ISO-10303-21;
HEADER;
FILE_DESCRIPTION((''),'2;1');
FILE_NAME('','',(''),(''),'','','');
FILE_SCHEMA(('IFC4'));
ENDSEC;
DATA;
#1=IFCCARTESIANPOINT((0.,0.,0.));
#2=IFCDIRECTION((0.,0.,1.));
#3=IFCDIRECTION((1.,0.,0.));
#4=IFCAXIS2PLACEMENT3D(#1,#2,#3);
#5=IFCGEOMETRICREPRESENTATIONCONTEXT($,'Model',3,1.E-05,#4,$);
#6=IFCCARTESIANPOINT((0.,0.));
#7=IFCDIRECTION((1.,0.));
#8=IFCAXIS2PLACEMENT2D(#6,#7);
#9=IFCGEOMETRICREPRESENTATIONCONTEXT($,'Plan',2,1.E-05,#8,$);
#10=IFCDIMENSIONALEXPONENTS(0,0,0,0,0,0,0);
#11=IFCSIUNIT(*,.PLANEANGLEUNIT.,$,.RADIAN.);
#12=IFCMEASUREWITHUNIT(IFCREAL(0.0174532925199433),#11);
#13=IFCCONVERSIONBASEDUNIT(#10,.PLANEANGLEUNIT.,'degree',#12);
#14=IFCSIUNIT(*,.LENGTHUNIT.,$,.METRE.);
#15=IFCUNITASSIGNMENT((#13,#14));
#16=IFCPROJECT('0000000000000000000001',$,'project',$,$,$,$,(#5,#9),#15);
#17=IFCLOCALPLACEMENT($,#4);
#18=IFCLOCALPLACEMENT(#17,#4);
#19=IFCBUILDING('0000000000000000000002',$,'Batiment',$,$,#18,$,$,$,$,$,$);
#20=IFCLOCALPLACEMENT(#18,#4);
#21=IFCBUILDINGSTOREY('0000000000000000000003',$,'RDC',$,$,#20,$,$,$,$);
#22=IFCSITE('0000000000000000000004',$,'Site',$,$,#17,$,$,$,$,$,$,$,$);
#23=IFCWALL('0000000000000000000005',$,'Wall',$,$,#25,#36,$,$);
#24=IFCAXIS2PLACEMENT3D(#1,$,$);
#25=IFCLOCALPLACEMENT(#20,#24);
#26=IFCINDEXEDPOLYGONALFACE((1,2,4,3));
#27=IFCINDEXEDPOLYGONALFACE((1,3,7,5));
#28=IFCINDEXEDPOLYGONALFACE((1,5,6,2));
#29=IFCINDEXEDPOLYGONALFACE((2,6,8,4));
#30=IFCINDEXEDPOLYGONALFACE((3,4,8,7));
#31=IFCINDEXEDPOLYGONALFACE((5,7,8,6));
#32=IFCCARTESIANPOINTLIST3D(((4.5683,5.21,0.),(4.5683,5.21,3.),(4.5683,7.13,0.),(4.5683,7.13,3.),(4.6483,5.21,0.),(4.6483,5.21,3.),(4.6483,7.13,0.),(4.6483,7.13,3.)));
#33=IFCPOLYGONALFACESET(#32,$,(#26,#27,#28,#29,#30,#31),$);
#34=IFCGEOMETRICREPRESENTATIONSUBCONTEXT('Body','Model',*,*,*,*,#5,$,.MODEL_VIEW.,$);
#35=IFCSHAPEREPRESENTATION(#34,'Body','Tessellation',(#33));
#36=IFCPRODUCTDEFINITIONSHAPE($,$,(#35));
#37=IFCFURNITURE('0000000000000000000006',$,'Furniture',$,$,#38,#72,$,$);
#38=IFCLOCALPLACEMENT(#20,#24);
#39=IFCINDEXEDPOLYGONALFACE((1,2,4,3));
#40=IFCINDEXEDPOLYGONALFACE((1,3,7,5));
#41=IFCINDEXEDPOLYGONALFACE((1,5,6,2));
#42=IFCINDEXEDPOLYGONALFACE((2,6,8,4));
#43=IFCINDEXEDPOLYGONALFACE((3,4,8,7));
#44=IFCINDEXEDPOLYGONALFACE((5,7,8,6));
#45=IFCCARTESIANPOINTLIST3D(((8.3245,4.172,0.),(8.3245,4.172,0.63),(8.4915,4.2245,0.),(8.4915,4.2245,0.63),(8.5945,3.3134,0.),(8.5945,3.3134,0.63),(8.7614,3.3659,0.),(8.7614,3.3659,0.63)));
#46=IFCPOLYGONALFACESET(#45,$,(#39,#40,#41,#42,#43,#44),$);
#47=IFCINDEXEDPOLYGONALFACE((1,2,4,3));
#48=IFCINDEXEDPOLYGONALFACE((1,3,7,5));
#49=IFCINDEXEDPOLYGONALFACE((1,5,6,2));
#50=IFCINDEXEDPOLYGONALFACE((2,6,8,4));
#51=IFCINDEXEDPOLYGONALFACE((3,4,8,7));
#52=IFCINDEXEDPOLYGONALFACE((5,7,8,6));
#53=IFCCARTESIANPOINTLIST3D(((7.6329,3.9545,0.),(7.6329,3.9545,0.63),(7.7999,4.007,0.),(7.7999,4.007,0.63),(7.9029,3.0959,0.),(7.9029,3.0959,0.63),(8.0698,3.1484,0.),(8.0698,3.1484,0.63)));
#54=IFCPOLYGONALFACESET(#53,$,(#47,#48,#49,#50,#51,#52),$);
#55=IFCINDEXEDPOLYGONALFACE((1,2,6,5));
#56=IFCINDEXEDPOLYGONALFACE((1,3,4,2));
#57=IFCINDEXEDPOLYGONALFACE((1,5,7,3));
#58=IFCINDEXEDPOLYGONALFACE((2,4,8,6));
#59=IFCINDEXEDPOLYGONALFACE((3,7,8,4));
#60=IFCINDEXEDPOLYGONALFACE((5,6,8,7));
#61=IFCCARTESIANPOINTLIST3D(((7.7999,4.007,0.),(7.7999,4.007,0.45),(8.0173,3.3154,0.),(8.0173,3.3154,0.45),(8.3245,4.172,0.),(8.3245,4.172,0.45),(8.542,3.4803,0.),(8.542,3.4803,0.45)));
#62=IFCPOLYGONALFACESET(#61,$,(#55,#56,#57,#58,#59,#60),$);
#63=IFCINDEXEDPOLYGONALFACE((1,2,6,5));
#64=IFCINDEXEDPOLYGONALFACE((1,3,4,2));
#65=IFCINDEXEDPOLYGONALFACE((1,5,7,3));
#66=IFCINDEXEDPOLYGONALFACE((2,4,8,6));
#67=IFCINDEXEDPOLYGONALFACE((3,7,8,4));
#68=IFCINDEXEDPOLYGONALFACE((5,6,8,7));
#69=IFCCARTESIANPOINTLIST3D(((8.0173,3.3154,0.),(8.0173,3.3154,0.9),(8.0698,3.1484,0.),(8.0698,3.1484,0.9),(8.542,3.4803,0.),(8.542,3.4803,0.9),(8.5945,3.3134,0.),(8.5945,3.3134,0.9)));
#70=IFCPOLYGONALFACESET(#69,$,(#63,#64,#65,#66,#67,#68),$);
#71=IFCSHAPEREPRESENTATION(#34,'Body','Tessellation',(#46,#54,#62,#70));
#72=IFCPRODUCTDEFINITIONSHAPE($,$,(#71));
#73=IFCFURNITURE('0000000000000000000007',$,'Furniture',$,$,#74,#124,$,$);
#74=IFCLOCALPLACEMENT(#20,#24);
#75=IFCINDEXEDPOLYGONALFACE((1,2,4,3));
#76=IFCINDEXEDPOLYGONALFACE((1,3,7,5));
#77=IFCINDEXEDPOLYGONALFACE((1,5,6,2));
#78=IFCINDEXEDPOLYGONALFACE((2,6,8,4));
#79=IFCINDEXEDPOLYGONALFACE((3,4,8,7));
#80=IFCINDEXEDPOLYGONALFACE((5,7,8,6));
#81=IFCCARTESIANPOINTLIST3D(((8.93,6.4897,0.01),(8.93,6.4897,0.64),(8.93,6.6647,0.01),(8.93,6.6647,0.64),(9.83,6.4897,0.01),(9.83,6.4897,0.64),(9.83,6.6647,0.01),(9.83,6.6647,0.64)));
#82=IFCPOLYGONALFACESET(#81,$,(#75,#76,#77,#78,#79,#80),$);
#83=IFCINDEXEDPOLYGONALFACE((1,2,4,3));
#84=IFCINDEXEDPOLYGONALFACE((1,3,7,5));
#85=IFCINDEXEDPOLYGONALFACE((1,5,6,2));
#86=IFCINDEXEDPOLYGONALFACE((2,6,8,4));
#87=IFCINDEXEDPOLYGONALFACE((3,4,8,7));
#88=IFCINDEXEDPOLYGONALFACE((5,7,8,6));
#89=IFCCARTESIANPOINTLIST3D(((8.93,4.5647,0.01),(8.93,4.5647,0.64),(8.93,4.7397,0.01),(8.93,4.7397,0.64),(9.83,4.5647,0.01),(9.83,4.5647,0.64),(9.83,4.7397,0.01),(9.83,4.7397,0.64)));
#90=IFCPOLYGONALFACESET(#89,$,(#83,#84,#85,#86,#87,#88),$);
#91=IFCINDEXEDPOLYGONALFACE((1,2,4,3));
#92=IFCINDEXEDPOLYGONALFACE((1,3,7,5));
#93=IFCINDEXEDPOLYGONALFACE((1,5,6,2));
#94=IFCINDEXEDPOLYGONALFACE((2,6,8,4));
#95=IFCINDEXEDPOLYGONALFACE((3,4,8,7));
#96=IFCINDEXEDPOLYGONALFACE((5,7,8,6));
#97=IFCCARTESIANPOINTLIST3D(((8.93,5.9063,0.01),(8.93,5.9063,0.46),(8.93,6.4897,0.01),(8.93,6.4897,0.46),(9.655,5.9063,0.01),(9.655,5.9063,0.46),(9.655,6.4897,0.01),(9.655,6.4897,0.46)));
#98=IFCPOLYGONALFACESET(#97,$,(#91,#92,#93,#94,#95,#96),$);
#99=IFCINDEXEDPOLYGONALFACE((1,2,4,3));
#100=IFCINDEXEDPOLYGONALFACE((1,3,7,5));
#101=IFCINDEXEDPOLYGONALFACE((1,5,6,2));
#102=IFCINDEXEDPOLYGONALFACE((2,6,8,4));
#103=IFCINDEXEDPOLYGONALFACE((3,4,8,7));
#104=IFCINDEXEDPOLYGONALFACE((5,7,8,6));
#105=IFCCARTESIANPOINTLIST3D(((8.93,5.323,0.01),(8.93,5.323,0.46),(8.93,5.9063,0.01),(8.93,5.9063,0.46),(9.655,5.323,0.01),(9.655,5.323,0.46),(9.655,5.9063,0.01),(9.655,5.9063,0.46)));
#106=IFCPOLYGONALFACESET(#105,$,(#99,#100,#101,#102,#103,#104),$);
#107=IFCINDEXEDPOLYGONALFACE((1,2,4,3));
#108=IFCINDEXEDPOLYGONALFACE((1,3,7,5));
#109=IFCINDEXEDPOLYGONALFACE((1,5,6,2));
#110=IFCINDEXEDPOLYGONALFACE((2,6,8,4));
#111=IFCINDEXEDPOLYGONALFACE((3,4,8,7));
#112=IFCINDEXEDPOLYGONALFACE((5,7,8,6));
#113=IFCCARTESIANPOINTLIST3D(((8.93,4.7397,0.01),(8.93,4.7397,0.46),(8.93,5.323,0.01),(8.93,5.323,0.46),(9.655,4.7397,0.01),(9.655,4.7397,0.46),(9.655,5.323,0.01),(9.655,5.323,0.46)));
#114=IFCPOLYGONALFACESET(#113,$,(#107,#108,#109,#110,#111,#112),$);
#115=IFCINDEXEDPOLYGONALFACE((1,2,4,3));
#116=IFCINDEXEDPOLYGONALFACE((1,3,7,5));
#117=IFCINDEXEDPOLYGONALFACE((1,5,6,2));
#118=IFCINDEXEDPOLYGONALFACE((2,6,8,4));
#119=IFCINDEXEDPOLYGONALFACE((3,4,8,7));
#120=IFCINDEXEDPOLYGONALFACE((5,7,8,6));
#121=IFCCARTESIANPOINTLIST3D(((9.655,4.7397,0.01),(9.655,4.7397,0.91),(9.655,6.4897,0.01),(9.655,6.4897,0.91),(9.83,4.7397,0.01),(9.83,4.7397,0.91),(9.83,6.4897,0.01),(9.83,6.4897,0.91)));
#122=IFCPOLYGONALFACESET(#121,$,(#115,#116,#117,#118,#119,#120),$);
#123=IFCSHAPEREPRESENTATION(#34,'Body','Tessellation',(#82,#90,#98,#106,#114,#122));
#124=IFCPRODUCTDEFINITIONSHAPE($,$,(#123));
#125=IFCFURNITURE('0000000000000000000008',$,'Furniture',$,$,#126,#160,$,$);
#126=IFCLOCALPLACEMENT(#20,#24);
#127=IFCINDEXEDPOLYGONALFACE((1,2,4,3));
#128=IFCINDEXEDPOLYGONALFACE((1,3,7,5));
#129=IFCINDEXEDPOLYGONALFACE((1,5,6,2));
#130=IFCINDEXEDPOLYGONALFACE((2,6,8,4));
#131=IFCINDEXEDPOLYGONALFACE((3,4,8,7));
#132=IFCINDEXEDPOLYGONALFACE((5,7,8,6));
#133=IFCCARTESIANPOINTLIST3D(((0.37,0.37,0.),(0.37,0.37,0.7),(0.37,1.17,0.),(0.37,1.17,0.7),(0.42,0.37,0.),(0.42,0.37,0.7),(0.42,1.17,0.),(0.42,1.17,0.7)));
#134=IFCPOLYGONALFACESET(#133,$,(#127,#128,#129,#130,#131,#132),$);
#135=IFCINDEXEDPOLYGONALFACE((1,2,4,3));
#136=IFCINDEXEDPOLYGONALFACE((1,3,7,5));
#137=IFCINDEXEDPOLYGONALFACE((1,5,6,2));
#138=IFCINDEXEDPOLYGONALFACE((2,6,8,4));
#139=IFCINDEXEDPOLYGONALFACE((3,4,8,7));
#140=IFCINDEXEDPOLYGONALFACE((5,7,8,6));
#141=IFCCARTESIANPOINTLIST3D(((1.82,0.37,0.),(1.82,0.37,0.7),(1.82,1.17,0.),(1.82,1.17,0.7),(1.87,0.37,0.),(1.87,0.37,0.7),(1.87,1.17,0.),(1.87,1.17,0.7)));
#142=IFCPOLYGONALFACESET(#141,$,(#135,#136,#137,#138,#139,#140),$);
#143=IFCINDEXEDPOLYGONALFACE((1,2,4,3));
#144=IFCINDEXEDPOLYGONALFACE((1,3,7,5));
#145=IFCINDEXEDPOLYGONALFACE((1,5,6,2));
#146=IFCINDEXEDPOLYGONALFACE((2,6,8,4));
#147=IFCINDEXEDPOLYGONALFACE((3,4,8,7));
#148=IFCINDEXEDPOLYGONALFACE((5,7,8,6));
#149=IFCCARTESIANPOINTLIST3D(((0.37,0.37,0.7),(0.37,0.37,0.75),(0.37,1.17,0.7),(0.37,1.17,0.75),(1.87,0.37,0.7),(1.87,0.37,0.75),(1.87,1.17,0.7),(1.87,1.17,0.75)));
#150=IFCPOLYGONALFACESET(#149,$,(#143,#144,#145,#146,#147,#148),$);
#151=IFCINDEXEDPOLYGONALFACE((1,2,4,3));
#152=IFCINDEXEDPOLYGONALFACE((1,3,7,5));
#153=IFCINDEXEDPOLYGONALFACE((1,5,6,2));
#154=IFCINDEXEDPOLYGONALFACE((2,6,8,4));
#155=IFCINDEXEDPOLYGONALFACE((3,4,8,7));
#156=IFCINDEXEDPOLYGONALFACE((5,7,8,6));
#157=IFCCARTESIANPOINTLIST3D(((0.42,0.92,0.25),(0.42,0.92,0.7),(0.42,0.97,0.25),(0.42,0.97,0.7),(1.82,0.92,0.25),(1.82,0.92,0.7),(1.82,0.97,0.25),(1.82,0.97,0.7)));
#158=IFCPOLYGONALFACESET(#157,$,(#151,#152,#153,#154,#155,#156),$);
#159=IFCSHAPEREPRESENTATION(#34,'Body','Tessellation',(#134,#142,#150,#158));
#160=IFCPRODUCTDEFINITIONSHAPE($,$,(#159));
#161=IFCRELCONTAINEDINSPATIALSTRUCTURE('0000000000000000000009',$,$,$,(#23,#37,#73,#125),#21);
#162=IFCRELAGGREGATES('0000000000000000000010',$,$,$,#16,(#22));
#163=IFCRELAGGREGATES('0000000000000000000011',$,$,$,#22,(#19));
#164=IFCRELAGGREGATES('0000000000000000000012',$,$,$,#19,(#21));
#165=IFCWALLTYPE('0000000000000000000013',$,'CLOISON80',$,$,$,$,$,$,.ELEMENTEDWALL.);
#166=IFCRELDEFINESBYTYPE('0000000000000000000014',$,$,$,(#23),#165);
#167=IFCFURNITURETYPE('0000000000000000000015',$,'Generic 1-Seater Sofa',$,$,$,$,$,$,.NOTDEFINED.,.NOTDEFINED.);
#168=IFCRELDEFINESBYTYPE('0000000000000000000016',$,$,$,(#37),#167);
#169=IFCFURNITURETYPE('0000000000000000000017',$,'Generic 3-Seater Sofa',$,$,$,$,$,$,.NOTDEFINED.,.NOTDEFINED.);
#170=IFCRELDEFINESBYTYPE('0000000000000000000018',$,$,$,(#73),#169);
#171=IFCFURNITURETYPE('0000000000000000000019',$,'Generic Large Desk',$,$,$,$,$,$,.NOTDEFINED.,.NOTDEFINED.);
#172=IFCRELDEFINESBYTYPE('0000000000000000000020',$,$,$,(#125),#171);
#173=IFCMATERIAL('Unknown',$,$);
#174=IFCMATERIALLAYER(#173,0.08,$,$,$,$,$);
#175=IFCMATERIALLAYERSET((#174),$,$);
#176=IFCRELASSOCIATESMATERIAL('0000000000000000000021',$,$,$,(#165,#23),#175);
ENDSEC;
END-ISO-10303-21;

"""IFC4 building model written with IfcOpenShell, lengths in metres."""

from ifc_helpers import new_model, entity, si_unit, converted_unit, frame, origin_with_axes, origin_2d_with_axis, place, context, subcontext, project, spatial, line, indexed_curve, outline, extrude, shape, source, transform, mapped, material, layer, layer_set, layer_usage, type_object, type_shapes, element, save


model = new_model("IFC4")

# Units and contexts
model_context = context("Model", 3, precision=1e-05, world=origin_with_axes())
plan_context = context("Plan", 2, precision=1e-05, world=origin_2d_with_axis())
body_context_1 = subcontext(model_context, "Body", "Model", "MODEL_VIEW")
body_context_2 = subcontext(plan_context, "Body", "Plan", "PLAN_VIEW")
ifc_project = project(units=[converted_unit("PLANEANGLEUNIT", "degree", entity("IfcReal", 0.0174532925199433), si_unit("PLANEANGLEUNIT", "RADIAN"), dimensions=[0, 0, 0, 0, 0, 0, 0]), si_unit("LENGTHUNIT", "METRE")], contexts=[model_context, plan_context])

# Site, building, storey
site_placement = place(None, origin_with_axes())
site = spatial("IfcSite", under=ifc_project, at=site_placement, Name="Site")
building_placement = place(site_placement, origin_with_axes())
building = spatial("IfcBuilding", under=site, at=building_placement, Name="Batiment")
storey_placement = place(building_placement, origin_with_axes())
storey = spatial("IfcBuildingStorey", under=building, at=storey_placement, Name="RDC")

# Shared definitions
ifc_material = material(Name="Unknown")

# Shared definitions
ifc_layer_1 = layer(ifc_material, 0.08)
ifc_layer_set_1 = layer_set([ifc_layer_1])
wall_type_1 = type_object("IfcWallType", Name="CLOISON80", PredefinedType="ELEMENTEDWALL", material=ifc_layer_set_1)

# Wall
ifc_layer_usage_1 = layer_usage(ifc_layer_set_1, "AXIS2", "POSITIVE", 0.0)
wall_1_placement = place(storey_placement, frame((4.6483, 5.21, 0.0), z_axis=(0.0, 0.0, 1.0), x_axis=(0.0, 1.0, 0.0)))
element("IfcWall", 1, at=wall_1_placement, inside=storey, type_object=wall_type_1, material=ifc_layer_usage_1, Name="Wall", context=body_context_1, shape_type="SweptSolid", body=[
    extrude(outline(indexed_curve([(0.0, 0.0), (0.0, 0.08), (1.92, 0.08), (1.92, 0.0), (0.0, 0.0)], self_intersect=False)), origin_with_axes(), (0.0, 0.0, 1.0), 3.0),
])

# Furniture
furniture_type_1 = type_object("IfcFurnitureType", Name="Generic 1-Seater Sofa", AssemblyPlace="NOTDEFINED", PredefinedType="NOTDEFINED")
shared_shape_1 = source(origin_with_axes(), body_context_1, "Body", "SweptSolid", [
    extrude(outline(indexed_curve([(0.0, 0.0), (0.175, 0.0), (0.175, 0.9), (0.0, 0.9)], segments=[line(1, 2, 3, 4, 1)])), frame((-0.45, -0.9, 0.0), z_axis=(0.0, 0.0, 1.0), x_axis=(1.0, 0.0, 0.0)), (0.0, 0.0, 1.0), 0.63),
    extrude(outline(indexed_curve([(0.0, 0.0), (0.175, 0.0), (0.175, 0.9), (0.0, 0.9)], segments=[line(1, 2, 3, 4, 1)])), frame((0.275, -0.9, 0.0), z_axis=(0.0, 0.0, 1.0), x_axis=(1.0, 0.0, 0.0)), (0.0, 0.0, 1.0), 0.63),
    extrude(outline(indexed_curve([(0.175, 0.0), (0.725, 0.0), (0.725, 0.725), (0.175, 0.725)], segments=[line(1, 2, 3, 4, 1)])), frame((-0.45, -0.9, 0.0), z_axis=(0.0, 0.0, 1.0), x_axis=(1.0, 0.0, 0.0)), (0.0, 0.0, 1.0), 0.45),
    extrude(outline(indexed_curve([(0.175, 0.725), (0.725, 0.725), (0.725, 0.9), (0.175, 0.9)], segments=[line(1, 2, 3, 4, 1)])), frame((-0.45, -0.9, 0.0), z_axis=(0.0, 0.0, 1.0), x_axis=(1.0, 0.0, 0.0)), (0.0, 0.0, 1.0), 0.9),
])
shared_shape_2 = source(origin_with_axes(), body_context_2, "Body", "Curve2D", [
    entity("IfcIndexedPolyCurve", entity("IfcCartesianPointList2D", [[-0.45, -0.9], [-0.275, -0.9], [-0.275, 0.0], [-0.45, 0.0]]), [entity("IfcLineIndex", [1, 2, 3, 4, 1])]),
    entity("IfcIndexedPolyCurve", entity("IfcCartesianPointList2D", [[0.275, -0.9], [0.45, -0.9], [0.45, 0.0], [0.275, 0.0]]), [entity("IfcLineIndex", [1, 2, 3, 4, 1])]),
    entity("IfcIndexedPolyCurve", entity("IfcCartesianPointList2D", [[-0.275, -0.9], [0.275, -0.9], [0.275, -0.175], [-0.275, -0.175]]), [entity("IfcLineIndex", [1, 2, 3, 4, 1])]),
    entity("IfcIndexedPolyCurve", entity("IfcCartesianPointList2D", [[-0.275, -0.175], [0.275, -0.175], [0.275, 0.0], [-0.275, 0.0]]), [entity("IfcLineIndex", [1, 2, 3, 4, 1])]),
])
type_shapes(furniture_type_1, [shared_shape_1, shared_shape_2])
furniture_1_placement = place(storey_placement, frame((8.3322, 3.2309, 0.0), z_axis=(0.0, 0.0, 1.0), x_axis=(-0.953955, -0.299951, 0.0)))
element("IfcFurniture", 2, at=furniture_1_placement, inside=storey, type_object=furniture_type_1, Name="Furniture", shapes=[
    shape(body_context_1, "Body", "MappedRepresentation", [mapped(shared_shape_1, transform((0.0, 0.0, 0.0), x_axis=(1.0, 0.0, 0.0), y_axis=(0.0, 1.0, 0.0), z_axis=(0.0, 0.0, 1.0), scale=1.0))]),
    shape(body_context_2, "Body", "MappedRepresentation", [mapped(shared_shape_2, transform((0.0, 0.0, 0.0), x_axis=(1.0, 0.0, 0.0), y_axis=(0.0, 1.0, 0.0), z_axis=(0.0, 0.0, 1.0), scale=1.0))]),
])
furniture_type_2 = type_object("IfcFurnitureType", Name="Generic 3-Seater Sofa", AssemblyPlace="NOTDEFINED", PredefinedType="NOTDEFINED")
shared_shape_3 = source(origin_with_axes(), body_context_1, "Body", "SweptSolid", [
    extrude(outline(indexed_curve([(0.0, 0.0), (0.175, 0.0), (0.175, 0.9), (0.0, 0.9)], segments=[line(1, 2, 3, 4, 1)])), frame((-1.05, -0.9, 0.0), z_axis=(0.0, 0.0, 1.0), x_axis=(1.0, 0.0, 0.0)), (0.0, 0.0, 1.0), 0.63),
    extrude(outline(indexed_curve([(0.0, 0.0), (0.175, 0.0), (0.175, 0.9), (0.0, 0.9)], segments=[line(1, 2, 3, 4, 1)])), frame((0.875, -0.9, 0.0), z_axis=(0.0, 0.0, 1.0), x_axis=(1.0, 0.0, 0.0)), (0.0, 0.0, 1.0), 0.63),
    extrude(outline(indexed_curve([(0.175, 0.0), (0.7583, 0.0), (0.7583, 0.725), (0.175, 0.725)], segments=[line(1, 2, 3, 4, 1)])), frame((-1.05, -0.9, 0.0), z_axis=(0.0, 0.0, 1.0), x_axis=(1.0, 0.0, 0.0)), (0.0, 0.0, 1.0), 0.45),
    extrude(outline(indexed_curve([(0.7583, 0.0), (1.3417, 0.0), (1.3417, 0.725), (0.7583, 0.725)], segments=[line(1, 2, 3, 4, 1)])), frame((-1.05, -0.9, 0.0), z_axis=(0.0, 0.0, 1.0), x_axis=(1.0, 0.0, 0.0)), (0.0, 0.0, 1.0), 0.45),
    extrude(outline(indexed_curve([(1.3417, 0.0), (1.925, 0.0), (1.925, 0.725), (1.3417, 0.725)], segments=[line(1, 2, 3, 4, 1)])), frame((-1.05, -0.9, 0.0), z_axis=(0.0, 0.0, 1.0), x_axis=(1.0, 0.0, 0.0)), (0.0, 0.0, 1.0), 0.45),
    extrude(outline(indexed_curve([(0.175, 0.725), (1.925, 0.725), (1.925, 0.9), (0.175, 0.9)], segments=[line(1, 2, 3, 4, 1)])), frame((-1.05, -0.9, 0.0), z_axis=(0.0, 0.0, 1.0), x_axis=(1.0, 0.0, 0.0)), (0.0, 0.0, 1.0), 0.9),
])
shared_shape_4 = source(origin_with_axes(), body_context_2, "Body", "Curve2D", [
    entity("IfcIndexedPolyCurve", entity("IfcCartesianPointList2D", [[-1.05, -0.9], [-0.875, -0.9], [-0.875, 0.0], [-1.05, 0.0]]), [entity("IfcLineIndex", [1, 2, 3, 4, 1])]),
    entity("IfcIndexedPolyCurve", entity("IfcCartesianPointList2D", [[0.875, -0.9], [1.05, -0.9], [1.05, 0.0], [0.875, 0.0]]), [entity("IfcLineIndex", [1, 2, 3, 4, 1])]),
    entity("IfcIndexedPolyCurve", entity("IfcCartesianPointList2D", [[-0.875, -0.9], [-0.2917, -0.9], [-0.2917, -0.175], [-0.875, -0.175]]), [entity("IfcLineIndex", [1, 2, 3, 4, 1])]),
    entity("IfcIndexedPolyCurve", entity("IfcCartesianPointList2D", [[-0.2917, -0.9], [0.2917, -0.9], [0.2917, -0.175], [-0.2917, -0.175]]), [entity("IfcLineIndex", [1, 2, 3, 4, 1])]),
    entity("IfcIndexedPolyCurve", entity("IfcCartesianPointList2D", [[0.2917, -0.9], [0.875, -0.9], [0.875, -0.175], [0.2917, -0.175]]), [entity("IfcLineIndex", [1, 2, 3, 4, 1])]),
    entity("IfcIndexedPolyCurve", entity("IfcCartesianPointList2D", [[-0.875, -0.175], [0.875, -0.175], [0.875, 0.0], [-0.875, 0.0]]), [entity("IfcLineIndex", [1, 2, 3, 4, 1])]),
])
type_shapes(furniture_type_2, [shared_shape_3, shared_shape_4])
furniture_2_placement = place(storey_placement, frame((9.83, 5.6147, 0.01), z_axis=(0.0, 0.0, 1.0), x_axis=(0.0, -1.0, 0.0)))
element("IfcFurniture", 3, at=furniture_2_placement, inside=storey, type_object=furniture_type_2, Name="Furniture", shapes=[
    shape(body_context_1, "Body", "MappedRepresentation", [mapped(shared_shape_3, transform((0.0, 0.0, 0.0), x_axis=(1.0, 0.0, 0.0), y_axis=(0.0, 1.0, 0.0), z_axis=(0.0, 0.0, 1.0), scale=1.0))]),
    shape(body_context_2, "Body", "MappedRepresentation", [mapped(shared_shape_4, transform((0.0, 0.0, 0.0), x_axis=(1.0, 0.0, 0.0), y_axis=(0.0, 1.0, 0.0), z_axis=(0.0, 0.0, 1.0), scale=1.0))]),
])
furniture_type_3 = type_object("IfcFurnitureType", Name="Generic Large Desk", AssemblyPlace="NOTDEFINED", PredefinedType="NOTDEFINED")
shared_shape_5 = source(origin_with_axes(), body_context_1, "Body", "SweptSolid", [
    extrude(outline(indexed_curve([(0.0, 0.0), (0.05, 0.0), (0.05, 0.8), (0.0, 0.8)], segments=[line(1, 2, 3, 4, 1)])), origin_with_axes(), (0.0, 0.0, 1.0), 0.7),
    extrude(outline(indexed_curve([(0.0, 0.0), (0.05, 0.0), (0.05, 0.8), (0.0, 0.8)], segments=[line(1, 2, 3, 4, 1)])), frame((1.45, 0.0, 0.0), z_axis=(0.0, 0.0, 1.0), x_axis=(1.0, 0.0, 0.0)), (0.0, 0.0, 1.0), 0.7),
    extrude(outline(indexed_curve([(0.0, 0.0), (1.5, 0.0), (1.5, 0.8), (0.0, 0.8)], segments=[line(1, 2, 3, 4, 1)])), frame((0.0, 0.0, 0.7), z_axis=(0.0, 0.0, 1.0), x_axis=(1.0, 0.0, 0.0)), (0.0, 0.0, 1.0), 0.05),
    extrude(outline(indexed_curve([(0.05, 0.55), (1.45, 0.55), (1.45, 0.6), (0.05, 0.6)], segments=[line(1, 2, 3, 4, 1)])), frame((0.0, 0.0, 0.25), z_axis=(0.0, 0.0, 1.0), x_axis=(1.0, 0.0, 0.0)), (0.0, 0.0, 1.0), 0.45),
])
shared_shape_6 = source(origin_with_axes(), body_context_2, "Body", "Curve2D", [
    entity("IfcIndexedPolyCurve", entity("IfcCartesianPointList2D", [[0.0, 0.0], [1.5, 0.0], [1.5, 0.8], [0.0, 0.8]]), [entity("IfcLineIndex", [1, 2, 3, 4, 1])]),
])
type_shapes(furniture_type_3, [shared_shape_5, shared_shape_6])
furniture_3_placement = place(storey_placement, frame((0.37, 0.37, 0.0), z_axis=(0.0, 0.0, 1.0), x_axis=(1.0, 0.0, 0.0)))
element("IfcFurniture", 4, at=furniture_3_placement, inside=storey, type_object=furniture_type_3, Name="Furniture", shapes=[
    shape(body_context_1, "Body", "MappedRepresentation", [mapped(shared_shape_5, transform((0.0, 0.0, 0.0), x_axis=(1.0, 0.0, 0.0), y_axis=(0.0, 1.0, 0.0), z_axis=(0.0, 0.0, 1.0), scale=1.0))]),
    shape(body_context_2, "Body", "MappedRepresentation", [mapped(shared_shape_6, transform((0.0, 0.0, 0.0), x_axis=(1.0, 0.0, 0.0), y_axis=(0.0, 1.0, 0.0), z_axis=(0.0, 0.0, 1.0), scale=1.0))]),
])

save(model, "model.ifc")
